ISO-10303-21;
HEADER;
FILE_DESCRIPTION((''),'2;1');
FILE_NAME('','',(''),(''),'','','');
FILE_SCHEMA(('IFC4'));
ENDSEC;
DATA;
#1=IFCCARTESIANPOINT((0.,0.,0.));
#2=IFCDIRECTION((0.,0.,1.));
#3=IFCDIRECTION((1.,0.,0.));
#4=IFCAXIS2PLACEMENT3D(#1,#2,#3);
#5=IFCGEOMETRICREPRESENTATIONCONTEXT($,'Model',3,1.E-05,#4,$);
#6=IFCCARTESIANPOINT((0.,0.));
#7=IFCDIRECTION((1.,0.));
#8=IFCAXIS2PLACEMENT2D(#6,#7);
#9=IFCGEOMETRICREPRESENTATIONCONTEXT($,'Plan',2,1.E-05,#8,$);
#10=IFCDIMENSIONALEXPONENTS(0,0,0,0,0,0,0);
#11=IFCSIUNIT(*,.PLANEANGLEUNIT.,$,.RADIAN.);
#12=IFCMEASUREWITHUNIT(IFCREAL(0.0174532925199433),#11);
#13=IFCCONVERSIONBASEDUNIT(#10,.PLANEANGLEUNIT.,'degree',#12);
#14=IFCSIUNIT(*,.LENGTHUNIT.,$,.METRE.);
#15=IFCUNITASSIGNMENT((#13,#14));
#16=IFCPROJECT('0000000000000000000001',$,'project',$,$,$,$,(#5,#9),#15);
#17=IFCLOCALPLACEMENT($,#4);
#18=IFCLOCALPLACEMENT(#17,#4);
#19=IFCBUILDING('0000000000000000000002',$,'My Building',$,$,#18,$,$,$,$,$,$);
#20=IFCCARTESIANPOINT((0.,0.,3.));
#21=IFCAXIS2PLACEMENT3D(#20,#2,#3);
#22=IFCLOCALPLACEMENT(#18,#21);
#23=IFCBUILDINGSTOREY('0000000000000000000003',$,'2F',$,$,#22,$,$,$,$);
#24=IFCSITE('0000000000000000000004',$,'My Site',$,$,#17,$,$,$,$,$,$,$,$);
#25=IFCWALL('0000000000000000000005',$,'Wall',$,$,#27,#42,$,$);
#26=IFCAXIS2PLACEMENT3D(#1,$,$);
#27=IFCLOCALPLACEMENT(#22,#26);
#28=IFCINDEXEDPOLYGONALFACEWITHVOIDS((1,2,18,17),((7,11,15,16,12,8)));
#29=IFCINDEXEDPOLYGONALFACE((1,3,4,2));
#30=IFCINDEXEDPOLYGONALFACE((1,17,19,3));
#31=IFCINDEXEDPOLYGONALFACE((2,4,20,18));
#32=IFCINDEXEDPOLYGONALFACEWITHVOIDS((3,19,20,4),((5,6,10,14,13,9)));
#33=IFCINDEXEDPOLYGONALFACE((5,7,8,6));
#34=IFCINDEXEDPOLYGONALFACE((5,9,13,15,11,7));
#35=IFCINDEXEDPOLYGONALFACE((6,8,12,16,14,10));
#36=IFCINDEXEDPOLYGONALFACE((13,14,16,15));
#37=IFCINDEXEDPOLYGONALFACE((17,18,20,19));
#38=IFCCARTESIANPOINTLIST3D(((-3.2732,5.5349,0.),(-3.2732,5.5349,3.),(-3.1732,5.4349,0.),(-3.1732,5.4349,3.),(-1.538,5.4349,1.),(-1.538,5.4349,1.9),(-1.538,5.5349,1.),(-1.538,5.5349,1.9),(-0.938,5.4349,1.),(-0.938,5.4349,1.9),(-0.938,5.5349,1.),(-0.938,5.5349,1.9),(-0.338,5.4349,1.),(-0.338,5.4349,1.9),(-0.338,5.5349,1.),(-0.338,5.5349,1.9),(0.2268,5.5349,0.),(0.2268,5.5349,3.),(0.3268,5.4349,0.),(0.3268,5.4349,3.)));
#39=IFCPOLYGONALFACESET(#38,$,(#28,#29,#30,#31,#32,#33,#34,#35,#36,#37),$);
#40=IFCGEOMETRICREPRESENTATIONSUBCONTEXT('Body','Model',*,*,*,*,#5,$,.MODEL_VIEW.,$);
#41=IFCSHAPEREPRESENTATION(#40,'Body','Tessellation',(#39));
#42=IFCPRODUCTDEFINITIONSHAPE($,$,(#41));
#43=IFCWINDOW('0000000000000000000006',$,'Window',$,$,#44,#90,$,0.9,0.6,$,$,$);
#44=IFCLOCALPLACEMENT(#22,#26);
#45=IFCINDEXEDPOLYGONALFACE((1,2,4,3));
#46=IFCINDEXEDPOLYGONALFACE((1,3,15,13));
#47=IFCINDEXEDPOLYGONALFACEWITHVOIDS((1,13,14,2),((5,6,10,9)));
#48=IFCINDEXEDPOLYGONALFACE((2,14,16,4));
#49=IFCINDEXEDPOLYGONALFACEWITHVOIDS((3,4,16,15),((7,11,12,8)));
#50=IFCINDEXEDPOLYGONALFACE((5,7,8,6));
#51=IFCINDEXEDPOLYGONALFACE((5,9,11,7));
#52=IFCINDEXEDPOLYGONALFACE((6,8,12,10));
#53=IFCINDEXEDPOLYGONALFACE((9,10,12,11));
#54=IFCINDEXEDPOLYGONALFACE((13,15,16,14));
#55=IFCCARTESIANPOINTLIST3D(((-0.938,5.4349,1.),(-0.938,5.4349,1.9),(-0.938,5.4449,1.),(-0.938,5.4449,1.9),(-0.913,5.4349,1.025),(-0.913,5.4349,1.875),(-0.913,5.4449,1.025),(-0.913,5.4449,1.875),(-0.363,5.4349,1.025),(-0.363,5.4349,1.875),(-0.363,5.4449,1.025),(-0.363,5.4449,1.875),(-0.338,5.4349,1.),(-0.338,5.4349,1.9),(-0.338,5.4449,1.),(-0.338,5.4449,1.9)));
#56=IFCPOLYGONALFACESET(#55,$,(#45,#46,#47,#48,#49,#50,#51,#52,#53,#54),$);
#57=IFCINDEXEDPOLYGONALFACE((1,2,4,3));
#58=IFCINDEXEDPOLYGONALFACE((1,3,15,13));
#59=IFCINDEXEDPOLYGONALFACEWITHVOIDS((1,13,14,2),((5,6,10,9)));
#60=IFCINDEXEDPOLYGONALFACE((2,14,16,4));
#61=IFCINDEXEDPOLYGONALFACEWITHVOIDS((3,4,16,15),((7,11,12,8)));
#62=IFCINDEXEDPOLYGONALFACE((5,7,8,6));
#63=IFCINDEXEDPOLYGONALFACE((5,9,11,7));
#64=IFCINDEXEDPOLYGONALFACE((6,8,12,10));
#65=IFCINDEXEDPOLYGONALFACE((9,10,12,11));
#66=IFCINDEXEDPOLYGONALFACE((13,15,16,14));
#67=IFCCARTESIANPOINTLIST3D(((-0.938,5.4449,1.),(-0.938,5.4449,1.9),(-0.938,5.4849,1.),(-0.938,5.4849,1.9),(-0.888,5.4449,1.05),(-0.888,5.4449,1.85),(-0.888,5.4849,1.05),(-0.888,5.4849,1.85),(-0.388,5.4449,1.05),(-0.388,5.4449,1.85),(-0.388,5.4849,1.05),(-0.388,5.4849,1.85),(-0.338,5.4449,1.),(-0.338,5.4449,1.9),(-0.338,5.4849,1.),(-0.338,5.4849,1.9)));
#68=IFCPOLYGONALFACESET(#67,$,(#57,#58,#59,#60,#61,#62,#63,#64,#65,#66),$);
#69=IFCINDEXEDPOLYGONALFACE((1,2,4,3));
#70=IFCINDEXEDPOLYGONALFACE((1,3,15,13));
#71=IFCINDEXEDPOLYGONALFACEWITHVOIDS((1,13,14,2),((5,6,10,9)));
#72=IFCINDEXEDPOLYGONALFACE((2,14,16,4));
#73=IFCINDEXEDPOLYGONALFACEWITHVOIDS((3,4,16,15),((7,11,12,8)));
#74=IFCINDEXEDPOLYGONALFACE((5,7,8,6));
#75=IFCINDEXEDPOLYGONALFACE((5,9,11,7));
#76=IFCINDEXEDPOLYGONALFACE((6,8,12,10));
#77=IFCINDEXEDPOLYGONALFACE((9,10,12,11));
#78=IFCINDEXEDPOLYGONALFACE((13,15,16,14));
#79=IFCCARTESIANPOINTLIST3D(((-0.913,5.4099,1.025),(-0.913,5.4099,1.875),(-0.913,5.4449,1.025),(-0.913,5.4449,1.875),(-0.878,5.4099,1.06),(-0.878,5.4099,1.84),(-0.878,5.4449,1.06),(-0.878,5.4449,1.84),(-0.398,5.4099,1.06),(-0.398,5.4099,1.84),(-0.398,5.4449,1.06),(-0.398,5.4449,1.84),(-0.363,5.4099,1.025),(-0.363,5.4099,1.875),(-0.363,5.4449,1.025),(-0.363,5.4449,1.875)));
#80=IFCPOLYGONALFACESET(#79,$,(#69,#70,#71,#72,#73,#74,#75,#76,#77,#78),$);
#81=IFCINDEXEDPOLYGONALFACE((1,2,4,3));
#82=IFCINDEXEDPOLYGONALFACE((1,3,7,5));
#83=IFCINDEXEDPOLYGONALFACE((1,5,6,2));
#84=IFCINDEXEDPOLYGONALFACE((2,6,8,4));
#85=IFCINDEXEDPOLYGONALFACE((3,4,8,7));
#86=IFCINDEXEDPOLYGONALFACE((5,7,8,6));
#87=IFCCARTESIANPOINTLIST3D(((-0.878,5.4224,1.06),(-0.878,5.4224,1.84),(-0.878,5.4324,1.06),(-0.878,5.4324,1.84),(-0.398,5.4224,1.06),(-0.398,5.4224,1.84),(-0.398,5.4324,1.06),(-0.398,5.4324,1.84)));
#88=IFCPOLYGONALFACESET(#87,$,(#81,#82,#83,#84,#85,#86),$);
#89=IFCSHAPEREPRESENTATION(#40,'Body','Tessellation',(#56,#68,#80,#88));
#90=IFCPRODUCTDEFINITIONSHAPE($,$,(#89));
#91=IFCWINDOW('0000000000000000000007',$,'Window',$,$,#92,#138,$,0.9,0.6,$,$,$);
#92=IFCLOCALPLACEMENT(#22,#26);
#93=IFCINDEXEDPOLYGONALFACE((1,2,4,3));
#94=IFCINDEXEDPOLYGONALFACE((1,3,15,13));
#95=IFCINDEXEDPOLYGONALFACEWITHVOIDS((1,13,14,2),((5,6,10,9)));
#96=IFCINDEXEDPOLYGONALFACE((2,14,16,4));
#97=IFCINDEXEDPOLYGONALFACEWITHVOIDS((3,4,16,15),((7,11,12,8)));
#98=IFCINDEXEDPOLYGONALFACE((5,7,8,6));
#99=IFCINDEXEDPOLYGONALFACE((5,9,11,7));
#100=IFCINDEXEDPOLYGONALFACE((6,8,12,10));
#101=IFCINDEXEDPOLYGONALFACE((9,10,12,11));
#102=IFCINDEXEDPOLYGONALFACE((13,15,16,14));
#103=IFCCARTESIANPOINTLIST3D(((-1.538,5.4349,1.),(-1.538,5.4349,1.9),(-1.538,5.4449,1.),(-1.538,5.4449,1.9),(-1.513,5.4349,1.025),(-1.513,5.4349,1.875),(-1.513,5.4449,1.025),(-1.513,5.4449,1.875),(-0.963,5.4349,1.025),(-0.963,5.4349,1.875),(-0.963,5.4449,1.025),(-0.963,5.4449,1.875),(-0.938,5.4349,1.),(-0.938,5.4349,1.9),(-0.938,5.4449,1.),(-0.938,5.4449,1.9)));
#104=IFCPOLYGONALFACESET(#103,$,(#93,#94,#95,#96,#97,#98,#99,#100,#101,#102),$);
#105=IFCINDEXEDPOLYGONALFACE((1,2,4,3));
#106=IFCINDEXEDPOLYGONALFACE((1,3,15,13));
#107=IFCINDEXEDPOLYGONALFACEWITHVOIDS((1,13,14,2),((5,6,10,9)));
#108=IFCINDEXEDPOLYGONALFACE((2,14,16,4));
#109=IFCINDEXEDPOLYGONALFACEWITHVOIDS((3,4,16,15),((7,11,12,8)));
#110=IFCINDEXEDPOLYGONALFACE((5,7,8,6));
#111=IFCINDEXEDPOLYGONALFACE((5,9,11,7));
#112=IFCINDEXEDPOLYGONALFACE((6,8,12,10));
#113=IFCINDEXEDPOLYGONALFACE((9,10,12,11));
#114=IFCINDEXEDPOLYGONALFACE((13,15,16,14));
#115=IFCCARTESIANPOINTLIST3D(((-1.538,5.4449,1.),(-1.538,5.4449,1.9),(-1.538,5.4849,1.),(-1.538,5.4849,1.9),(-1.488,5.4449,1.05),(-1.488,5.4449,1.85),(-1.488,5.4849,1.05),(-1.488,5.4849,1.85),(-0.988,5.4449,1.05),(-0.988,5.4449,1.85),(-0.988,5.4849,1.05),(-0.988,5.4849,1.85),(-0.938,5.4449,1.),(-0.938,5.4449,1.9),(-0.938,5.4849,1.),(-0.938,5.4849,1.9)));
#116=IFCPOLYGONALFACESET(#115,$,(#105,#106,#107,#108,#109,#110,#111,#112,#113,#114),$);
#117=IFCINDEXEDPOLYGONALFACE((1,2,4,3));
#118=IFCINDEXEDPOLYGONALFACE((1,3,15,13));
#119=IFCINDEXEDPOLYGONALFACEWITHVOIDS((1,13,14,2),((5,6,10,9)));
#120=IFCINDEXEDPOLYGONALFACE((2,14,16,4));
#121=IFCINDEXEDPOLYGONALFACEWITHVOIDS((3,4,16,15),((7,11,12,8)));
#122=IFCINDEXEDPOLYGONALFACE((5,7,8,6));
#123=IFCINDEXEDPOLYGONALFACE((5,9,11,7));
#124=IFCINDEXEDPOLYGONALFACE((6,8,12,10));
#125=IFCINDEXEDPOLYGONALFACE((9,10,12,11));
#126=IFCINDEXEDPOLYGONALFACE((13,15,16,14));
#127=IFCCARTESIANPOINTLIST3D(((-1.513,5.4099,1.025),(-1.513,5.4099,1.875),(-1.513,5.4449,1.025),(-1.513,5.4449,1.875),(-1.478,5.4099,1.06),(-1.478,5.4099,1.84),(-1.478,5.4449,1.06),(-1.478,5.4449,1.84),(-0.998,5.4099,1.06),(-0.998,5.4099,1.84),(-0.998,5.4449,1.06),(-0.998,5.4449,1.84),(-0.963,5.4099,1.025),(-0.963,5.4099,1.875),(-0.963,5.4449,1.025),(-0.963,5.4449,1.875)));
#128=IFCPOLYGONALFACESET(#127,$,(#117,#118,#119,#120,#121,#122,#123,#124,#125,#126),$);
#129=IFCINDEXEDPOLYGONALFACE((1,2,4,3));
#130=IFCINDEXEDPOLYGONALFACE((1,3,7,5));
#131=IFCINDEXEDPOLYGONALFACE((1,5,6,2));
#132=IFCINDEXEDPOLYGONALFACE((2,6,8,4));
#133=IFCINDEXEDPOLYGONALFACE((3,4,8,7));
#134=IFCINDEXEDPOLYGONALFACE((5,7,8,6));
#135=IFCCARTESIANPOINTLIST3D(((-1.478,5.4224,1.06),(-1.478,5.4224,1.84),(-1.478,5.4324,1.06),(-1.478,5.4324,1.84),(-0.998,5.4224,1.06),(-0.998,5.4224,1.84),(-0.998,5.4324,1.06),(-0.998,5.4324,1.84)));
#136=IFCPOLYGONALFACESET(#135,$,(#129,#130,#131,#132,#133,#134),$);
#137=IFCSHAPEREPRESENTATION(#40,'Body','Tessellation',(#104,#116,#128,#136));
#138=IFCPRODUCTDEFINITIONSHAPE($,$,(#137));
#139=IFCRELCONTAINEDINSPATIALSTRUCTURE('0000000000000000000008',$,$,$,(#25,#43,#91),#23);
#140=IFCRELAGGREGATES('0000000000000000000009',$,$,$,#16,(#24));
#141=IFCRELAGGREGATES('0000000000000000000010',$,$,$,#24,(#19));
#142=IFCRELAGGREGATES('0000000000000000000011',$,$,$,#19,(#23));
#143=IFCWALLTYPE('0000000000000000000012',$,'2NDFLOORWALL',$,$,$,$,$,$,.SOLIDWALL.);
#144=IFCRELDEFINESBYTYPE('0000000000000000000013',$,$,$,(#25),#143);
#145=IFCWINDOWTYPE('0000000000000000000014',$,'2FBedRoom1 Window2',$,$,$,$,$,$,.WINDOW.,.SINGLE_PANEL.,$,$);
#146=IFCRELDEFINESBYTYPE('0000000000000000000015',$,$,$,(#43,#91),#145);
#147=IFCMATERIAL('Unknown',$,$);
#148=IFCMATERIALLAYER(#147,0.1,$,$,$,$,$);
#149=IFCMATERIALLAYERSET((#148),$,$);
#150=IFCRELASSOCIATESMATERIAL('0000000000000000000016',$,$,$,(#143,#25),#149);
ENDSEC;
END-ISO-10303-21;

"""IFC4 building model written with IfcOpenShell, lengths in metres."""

from ifc_helpers import new_model, entity, si_unit, converted_unit, frame, origin_with_axes, origin_2d_with_axis, place, context, subcontext, project, spatial, line, indexed_curve, outline, extrude, shape, source, transform, mapped, material, layer, layer_set, layer_usage, type_object, type_shapes, element, fill, save


model = new_model("IFC4")

# Units and contexts
model_context = context("Model", 3, precision=1e-05, world=origin_with_axes())
plan_context = context("Plan", 2, precision=1e-05, world=origin_2d_with_axis())
body_context_1 = subcontext(model_context, "Body", "Model", "MODEL_VIEW")
body_context_2 = subcontext(plan_context, "Body", "Plan", "PLAN_VIEW")
ifc_project = project(units=[converted_unit("PLANEANGLEUNIT", "degree", entity("IfcReal", 0.0174532925199433), si_unit("PLANEANGLEUNIT", "RADIAN"), dimensions=[0, 0, 0, 0, 0, 0, 0]), si_unit("LENGTHUNIT", "METRE")], contexts=[model_context, plan_context])

# Site, building, storey
site_placement = place(None, origin_with_axes())
site = spatial("IfcSite", under=ifc_project, at=site_placement, Name="My Site")
building_placement = place(site_placement, origin_with_axes())
building = spatial("IfcBuilding", under=site, at=building_placement, Name="My Building")
storey_placement = place(building_placement, frame((0.0, 0.0, 3.0), z_axis=(0.0, 0.0, 1.0), x_axis=(1.0, 0.0, 0.0)))
storey = spatial("IfcBuildingStorey", under=building, at=storey_placement, Name="2F")

# Shared definitions
ifc_material = material(Name="Unknown")

# Shared definitions
ifc_layer_1 = layer(ifc_material, 0.1)
ifc_layer_set_1 = layer_set([ifc_layer_1])
wall_type_1 = type_object("IfcWallType", Name="2NDFLOORWALL", PredefinedType="SOLIDWALL", material=ifc_layer_set_1)

# Wall, openings, windows
ifc_layer_usage_1 = layer_usage(ifc_layer_set_1, "AXIS2", "POSITIVE", 0.0)
wall_1_placement = place(storey_placement, frame((0.2268, 5.5349, 0.0), z_axis=(0.0, 0.0, 1.0), x_axis=(-1.0, 0.0, 0.0)))
wall_1 = element("IfcWall", 1, at=wall_1_placement, inside=storey, type_object=wall_type_1, material=ifc_layer_usage_1, Name="Wall", context=body_context_1, shape_type="SweptSolid", body=[
    extrude(outline(indexed_curve([(0.0, 0.0), (-0.1, 0.1), (3.4, 0.1), (3.5, 0.0)], segments=[line(1, 2, 3, 4, 1)])), origin_with_axes(), (0.0, 0.0, 1.0), 3.0),
])
shared_shape_1 = source(origin_with_axes(), body_context_1, "Body", "SweptSolid", [
    extrude(outline(indexed_curve([(0.0, 0.0), (0.6, 0.0), (0.6, 0.9), (0.0, 0.9)], segments=[line(1, 2, 3, 4, 1)])), frame((0.0, -0.6, 0.0), z_axis=(0.0, -1.0, 0.0), x_axis=(1.0, 0.0, 0.0)), (0.0, 0.0, -1.0), 1.2),
])
opening_1_placement = place(wall_1_placement, frame((0.5648, 0.0, 1.0), z_axis=(0.0, 0.0, 1.0), x_axis=(1.0, 0.0, 0.0)))
opening_1 = element("IfcOpeningElement", 2, at=opening_1_placement, cuts=wall_1, PredefinedType="OPENING", context=body_context_1, shape_type="MappedRepresentation", body=[
    mapped(shared_shape_1, transform((0.0, 0.0, 0.0), x_axis=(1.0, 0.0, 0.0), y_axis=(0.0, 1.0, 0.0), z_axis=(0.0, 0.0, 1.0), scale=1.0)),
])
opening_2_placement = place(wall_1_placement, frame((1.1648, 0.0, 1.0), z_axis=(0.0, 0.0, 1.0), x_axis=(1.0, 0.0, 0.0)))
opening_2 = element("IfcOpeningElement", 3, at=opening_2_placement, cuts=wall_1, PredefinedType="OPENING", context=body_context_1, shape_type="MappedRepresentation", body=[
    mapped(shared_shape_1, transform((0.0, 0.0, 0.0), x_axis=(1.0, 0.0, 0.0), y_axis=(0.0, 1.0, 0.0), z_axis=(0.0, 0.0, 1.0), scale=1.0)),
])
window_type_1 = type_object("IfcWindowType", Name="2FBedRoom1 Window2", PartitioningType="SINGLE_PANEL", PredefinedType="WINDOW")
shared_shape_2 = source(origin_with_axes(), body_context_1, "Body", "SweptSolid", [
    extrude(outline(indexed_curve([(0.0, 0.0), (0.6, 0.0), (0.6, 0.9), (0.0, 0.9)], segments=[line(1, 2, 3, 4, 1)]), holes=[indexed_curve([(0.025, 0.025), (0.575, 0.025), (0.575, 0.875), (0.025, 0.875)], segments=[line(1, 2, 3, 4, 1)])]), frame((0.0, 0.09, 0.0), z_axis=(0.0, -1.0, 0.0), x_axis=(1.0, 0.0, 0.0)), (0.0, 0.0, -1.0), 0.01),
    extrude(outline(indexed_curve([(0.0, 0.0), (0.6, 0.0), (0.6, 0.9), (0.0, 0.9)], segments=[line(1, 2, 3, 4, 1)]), holes=[indexed_curve([(0.05, 0.05), (0.55, 0.05), (0.55, 0.85), (0.05, 0.85)], segments=[line(1, 2, 3, 4, 1)])]), frame((0.0, 0.05, 0.0), z_axis=(0.0, -1.0, 0.0), x_axis=(1.0, 0.0, 0.0)), (0.0, 0.0, -1.0), 0.04),
    extrude(outline(indexed_curve([(0.0, 0.0), (0.55, 0.0), (0.55, 0.85), (0.0, 0.85)], segments=[line(1, 2, 3, 4, 1)]), holes=[indexed_curve([(0.035, 0.035), (0.515, 0.035), (0.515, 0.815), (0.035, 0.815)], segments=[line(1, 2, 3, 4, 1)])]), frame((0.025, 0.09, 0.025), z_axis=(0.0, -1.0, 0.0), x_axis=(1.0, 0.0, 0.0)), (0.0, 0.0, -1.0), 0.035),
    extrude(outline(indexed_curve([(0.035, 0.035), (0.515, 0.035), (0.515, 0.815), (0.035, 0.815)], segments=[line(1, 2, 3, 4, 1)])), frame((0.025, 0.1025, 0.025), z_axis=(0.0, -1.0, 0.0), x_axis=(1.0, 0.0, 0.0)), (0.0, 0.0, -1.0), 0.01),
])
shared_shape_3 = source(origin_with_axes(), body_context_2, "Body", "Curve2D", [
    entity("IfcIndexedPolyCurve", entity("IfcCartesianPointList2D", [[0.05, 0.05], [0.55, 0.05]])),
    entity("IfcIndexedPolyCurve", entity("IfcCartesianPointList2D", [[0.0, 0.1], [0.025, 0.1], [0.025, 0.09], [0.05, 0.09], [0.05, 0.05], [0.0, 0.05]]), [entity("IfcLineIndex", [1, 2, 3, 4, 5, 6, 1])]),
    entity("IfcIndexedPolyCurve", entity("IfcCartesianPointList2D", [[0.6, 0.1], [0.575, 0.1], [0.575, 0.09], [0.55, 0.09], [0.55, 0.05], [0.6, 0.05]]), [entity("IfcLineIndex", [1, 2, 3, 4, 5, 6, 1])]),
    entity("IfcIndexedPolyCurve", entity("IfcCartesianPointList2D", [[0.025, 0.09], [0.06, 0.09], [0.06, 0.125], [0.025, 0.125]]), [entity("IfcLineIndex", [1, 2, 3, 4, 1])]),
    entity("IfcIndexedPolyCurve", entity("IfcCartesianPointList2D", [[0.575, 0.09], [0.54, 0.09], [0.54, 0.125], [0.575, 0.125]]), [entity("IfcLineIndex", [1, 2, 3, 4, 1])]),
    entity("IfcIndexedPolyCurve", entity("IfcCartesianPointList2D", [[0.06, 0.09], [0.54, 0.09]])),
    entity("IfcIndexedPolyCurve", entity("IfcCartesianPointList2D", [[0.06, 0.125], [0.54, 0.125]])),
    entity("IfcIndexedPolyCurve", entity("IfcCartesianPointList2D", [[0.06, 0.1075], [0.54, 0.1075]])),
])
type_shapes(window_type_1, [shared_shape_2, shared_shape_3])
window_1_placement = place(opening_1_placement, frame((0.0, 0.0, 0.0), z_axis=(0.0, 0.0, 1.0), x_axis=(1.0, 0.0, 0.0)))
window_1 = element("IfcWindow", 4, at=window_1_placement, inside=storey, type_object=window_type_1, Name="Window", OverallHeight=0.9, OverallWidth=0.6, shapes=[
    shape(body_context_1, "Body", "MappedRepresentation", [mapped(shared_shape_2, transform((0.0, 0.0, 0.0), x_axis=(1.0, 0.0, 0.0), y_axis=(0.0, 1.0, 0.0), z_axis=(0.0, 0.0, 1.0), scale=1.0))]),
    shape(body_context_2, "Body", "MappedRepresentation", [mapped(shared_shape_3, transform((0.0, 0.0, 0.0), x_axis=(1.0, 0.0, 0.0), y_axis=(0.0, 1.0, 0.0), z_axis=(0.0, 0.0, 1.0), scale=1.0))]),
])
fill(opening_1, window_1)
window_2_placement = place(opening_2_placement, frame((0.0, 0.0, 0.0), z_axis=(0.0, 0.0, 1.0), x_axis=(1.0, 0.0, 0.0)))
window_2 = element("IfcWindow", 5, at=window_2_placement, inside=storey, type_object=window_type_1, Name="Window", OverallHeight=0.9, OverallWidth=0.6, shapes=[
    shape(body_context_1, "Body", "MappedRepresentation", [mapped(shared_shape_2, transform((0.0, 0.0, 0.0), x_axis=(1.0, 0.0, 0.0), y_axis=(0.0, 1.0, 0.0), z_axis=(0.0, 0.0, 1.0), scale=1.0))]),
    shape(body_context_2, "Body", "MappedRepresentation", [mapped(shared_shape_3, transform((0.0, 0.0, 0.0), x_axis=(1.0, 0.0, 0.0), y_axis=(0.0, 1.0, 0.0), z_axis=(0.0, 0.0, 1.0), scale=1.0))]),
])
fill(opening_2, window_2)

save(model, "model.ifc")
